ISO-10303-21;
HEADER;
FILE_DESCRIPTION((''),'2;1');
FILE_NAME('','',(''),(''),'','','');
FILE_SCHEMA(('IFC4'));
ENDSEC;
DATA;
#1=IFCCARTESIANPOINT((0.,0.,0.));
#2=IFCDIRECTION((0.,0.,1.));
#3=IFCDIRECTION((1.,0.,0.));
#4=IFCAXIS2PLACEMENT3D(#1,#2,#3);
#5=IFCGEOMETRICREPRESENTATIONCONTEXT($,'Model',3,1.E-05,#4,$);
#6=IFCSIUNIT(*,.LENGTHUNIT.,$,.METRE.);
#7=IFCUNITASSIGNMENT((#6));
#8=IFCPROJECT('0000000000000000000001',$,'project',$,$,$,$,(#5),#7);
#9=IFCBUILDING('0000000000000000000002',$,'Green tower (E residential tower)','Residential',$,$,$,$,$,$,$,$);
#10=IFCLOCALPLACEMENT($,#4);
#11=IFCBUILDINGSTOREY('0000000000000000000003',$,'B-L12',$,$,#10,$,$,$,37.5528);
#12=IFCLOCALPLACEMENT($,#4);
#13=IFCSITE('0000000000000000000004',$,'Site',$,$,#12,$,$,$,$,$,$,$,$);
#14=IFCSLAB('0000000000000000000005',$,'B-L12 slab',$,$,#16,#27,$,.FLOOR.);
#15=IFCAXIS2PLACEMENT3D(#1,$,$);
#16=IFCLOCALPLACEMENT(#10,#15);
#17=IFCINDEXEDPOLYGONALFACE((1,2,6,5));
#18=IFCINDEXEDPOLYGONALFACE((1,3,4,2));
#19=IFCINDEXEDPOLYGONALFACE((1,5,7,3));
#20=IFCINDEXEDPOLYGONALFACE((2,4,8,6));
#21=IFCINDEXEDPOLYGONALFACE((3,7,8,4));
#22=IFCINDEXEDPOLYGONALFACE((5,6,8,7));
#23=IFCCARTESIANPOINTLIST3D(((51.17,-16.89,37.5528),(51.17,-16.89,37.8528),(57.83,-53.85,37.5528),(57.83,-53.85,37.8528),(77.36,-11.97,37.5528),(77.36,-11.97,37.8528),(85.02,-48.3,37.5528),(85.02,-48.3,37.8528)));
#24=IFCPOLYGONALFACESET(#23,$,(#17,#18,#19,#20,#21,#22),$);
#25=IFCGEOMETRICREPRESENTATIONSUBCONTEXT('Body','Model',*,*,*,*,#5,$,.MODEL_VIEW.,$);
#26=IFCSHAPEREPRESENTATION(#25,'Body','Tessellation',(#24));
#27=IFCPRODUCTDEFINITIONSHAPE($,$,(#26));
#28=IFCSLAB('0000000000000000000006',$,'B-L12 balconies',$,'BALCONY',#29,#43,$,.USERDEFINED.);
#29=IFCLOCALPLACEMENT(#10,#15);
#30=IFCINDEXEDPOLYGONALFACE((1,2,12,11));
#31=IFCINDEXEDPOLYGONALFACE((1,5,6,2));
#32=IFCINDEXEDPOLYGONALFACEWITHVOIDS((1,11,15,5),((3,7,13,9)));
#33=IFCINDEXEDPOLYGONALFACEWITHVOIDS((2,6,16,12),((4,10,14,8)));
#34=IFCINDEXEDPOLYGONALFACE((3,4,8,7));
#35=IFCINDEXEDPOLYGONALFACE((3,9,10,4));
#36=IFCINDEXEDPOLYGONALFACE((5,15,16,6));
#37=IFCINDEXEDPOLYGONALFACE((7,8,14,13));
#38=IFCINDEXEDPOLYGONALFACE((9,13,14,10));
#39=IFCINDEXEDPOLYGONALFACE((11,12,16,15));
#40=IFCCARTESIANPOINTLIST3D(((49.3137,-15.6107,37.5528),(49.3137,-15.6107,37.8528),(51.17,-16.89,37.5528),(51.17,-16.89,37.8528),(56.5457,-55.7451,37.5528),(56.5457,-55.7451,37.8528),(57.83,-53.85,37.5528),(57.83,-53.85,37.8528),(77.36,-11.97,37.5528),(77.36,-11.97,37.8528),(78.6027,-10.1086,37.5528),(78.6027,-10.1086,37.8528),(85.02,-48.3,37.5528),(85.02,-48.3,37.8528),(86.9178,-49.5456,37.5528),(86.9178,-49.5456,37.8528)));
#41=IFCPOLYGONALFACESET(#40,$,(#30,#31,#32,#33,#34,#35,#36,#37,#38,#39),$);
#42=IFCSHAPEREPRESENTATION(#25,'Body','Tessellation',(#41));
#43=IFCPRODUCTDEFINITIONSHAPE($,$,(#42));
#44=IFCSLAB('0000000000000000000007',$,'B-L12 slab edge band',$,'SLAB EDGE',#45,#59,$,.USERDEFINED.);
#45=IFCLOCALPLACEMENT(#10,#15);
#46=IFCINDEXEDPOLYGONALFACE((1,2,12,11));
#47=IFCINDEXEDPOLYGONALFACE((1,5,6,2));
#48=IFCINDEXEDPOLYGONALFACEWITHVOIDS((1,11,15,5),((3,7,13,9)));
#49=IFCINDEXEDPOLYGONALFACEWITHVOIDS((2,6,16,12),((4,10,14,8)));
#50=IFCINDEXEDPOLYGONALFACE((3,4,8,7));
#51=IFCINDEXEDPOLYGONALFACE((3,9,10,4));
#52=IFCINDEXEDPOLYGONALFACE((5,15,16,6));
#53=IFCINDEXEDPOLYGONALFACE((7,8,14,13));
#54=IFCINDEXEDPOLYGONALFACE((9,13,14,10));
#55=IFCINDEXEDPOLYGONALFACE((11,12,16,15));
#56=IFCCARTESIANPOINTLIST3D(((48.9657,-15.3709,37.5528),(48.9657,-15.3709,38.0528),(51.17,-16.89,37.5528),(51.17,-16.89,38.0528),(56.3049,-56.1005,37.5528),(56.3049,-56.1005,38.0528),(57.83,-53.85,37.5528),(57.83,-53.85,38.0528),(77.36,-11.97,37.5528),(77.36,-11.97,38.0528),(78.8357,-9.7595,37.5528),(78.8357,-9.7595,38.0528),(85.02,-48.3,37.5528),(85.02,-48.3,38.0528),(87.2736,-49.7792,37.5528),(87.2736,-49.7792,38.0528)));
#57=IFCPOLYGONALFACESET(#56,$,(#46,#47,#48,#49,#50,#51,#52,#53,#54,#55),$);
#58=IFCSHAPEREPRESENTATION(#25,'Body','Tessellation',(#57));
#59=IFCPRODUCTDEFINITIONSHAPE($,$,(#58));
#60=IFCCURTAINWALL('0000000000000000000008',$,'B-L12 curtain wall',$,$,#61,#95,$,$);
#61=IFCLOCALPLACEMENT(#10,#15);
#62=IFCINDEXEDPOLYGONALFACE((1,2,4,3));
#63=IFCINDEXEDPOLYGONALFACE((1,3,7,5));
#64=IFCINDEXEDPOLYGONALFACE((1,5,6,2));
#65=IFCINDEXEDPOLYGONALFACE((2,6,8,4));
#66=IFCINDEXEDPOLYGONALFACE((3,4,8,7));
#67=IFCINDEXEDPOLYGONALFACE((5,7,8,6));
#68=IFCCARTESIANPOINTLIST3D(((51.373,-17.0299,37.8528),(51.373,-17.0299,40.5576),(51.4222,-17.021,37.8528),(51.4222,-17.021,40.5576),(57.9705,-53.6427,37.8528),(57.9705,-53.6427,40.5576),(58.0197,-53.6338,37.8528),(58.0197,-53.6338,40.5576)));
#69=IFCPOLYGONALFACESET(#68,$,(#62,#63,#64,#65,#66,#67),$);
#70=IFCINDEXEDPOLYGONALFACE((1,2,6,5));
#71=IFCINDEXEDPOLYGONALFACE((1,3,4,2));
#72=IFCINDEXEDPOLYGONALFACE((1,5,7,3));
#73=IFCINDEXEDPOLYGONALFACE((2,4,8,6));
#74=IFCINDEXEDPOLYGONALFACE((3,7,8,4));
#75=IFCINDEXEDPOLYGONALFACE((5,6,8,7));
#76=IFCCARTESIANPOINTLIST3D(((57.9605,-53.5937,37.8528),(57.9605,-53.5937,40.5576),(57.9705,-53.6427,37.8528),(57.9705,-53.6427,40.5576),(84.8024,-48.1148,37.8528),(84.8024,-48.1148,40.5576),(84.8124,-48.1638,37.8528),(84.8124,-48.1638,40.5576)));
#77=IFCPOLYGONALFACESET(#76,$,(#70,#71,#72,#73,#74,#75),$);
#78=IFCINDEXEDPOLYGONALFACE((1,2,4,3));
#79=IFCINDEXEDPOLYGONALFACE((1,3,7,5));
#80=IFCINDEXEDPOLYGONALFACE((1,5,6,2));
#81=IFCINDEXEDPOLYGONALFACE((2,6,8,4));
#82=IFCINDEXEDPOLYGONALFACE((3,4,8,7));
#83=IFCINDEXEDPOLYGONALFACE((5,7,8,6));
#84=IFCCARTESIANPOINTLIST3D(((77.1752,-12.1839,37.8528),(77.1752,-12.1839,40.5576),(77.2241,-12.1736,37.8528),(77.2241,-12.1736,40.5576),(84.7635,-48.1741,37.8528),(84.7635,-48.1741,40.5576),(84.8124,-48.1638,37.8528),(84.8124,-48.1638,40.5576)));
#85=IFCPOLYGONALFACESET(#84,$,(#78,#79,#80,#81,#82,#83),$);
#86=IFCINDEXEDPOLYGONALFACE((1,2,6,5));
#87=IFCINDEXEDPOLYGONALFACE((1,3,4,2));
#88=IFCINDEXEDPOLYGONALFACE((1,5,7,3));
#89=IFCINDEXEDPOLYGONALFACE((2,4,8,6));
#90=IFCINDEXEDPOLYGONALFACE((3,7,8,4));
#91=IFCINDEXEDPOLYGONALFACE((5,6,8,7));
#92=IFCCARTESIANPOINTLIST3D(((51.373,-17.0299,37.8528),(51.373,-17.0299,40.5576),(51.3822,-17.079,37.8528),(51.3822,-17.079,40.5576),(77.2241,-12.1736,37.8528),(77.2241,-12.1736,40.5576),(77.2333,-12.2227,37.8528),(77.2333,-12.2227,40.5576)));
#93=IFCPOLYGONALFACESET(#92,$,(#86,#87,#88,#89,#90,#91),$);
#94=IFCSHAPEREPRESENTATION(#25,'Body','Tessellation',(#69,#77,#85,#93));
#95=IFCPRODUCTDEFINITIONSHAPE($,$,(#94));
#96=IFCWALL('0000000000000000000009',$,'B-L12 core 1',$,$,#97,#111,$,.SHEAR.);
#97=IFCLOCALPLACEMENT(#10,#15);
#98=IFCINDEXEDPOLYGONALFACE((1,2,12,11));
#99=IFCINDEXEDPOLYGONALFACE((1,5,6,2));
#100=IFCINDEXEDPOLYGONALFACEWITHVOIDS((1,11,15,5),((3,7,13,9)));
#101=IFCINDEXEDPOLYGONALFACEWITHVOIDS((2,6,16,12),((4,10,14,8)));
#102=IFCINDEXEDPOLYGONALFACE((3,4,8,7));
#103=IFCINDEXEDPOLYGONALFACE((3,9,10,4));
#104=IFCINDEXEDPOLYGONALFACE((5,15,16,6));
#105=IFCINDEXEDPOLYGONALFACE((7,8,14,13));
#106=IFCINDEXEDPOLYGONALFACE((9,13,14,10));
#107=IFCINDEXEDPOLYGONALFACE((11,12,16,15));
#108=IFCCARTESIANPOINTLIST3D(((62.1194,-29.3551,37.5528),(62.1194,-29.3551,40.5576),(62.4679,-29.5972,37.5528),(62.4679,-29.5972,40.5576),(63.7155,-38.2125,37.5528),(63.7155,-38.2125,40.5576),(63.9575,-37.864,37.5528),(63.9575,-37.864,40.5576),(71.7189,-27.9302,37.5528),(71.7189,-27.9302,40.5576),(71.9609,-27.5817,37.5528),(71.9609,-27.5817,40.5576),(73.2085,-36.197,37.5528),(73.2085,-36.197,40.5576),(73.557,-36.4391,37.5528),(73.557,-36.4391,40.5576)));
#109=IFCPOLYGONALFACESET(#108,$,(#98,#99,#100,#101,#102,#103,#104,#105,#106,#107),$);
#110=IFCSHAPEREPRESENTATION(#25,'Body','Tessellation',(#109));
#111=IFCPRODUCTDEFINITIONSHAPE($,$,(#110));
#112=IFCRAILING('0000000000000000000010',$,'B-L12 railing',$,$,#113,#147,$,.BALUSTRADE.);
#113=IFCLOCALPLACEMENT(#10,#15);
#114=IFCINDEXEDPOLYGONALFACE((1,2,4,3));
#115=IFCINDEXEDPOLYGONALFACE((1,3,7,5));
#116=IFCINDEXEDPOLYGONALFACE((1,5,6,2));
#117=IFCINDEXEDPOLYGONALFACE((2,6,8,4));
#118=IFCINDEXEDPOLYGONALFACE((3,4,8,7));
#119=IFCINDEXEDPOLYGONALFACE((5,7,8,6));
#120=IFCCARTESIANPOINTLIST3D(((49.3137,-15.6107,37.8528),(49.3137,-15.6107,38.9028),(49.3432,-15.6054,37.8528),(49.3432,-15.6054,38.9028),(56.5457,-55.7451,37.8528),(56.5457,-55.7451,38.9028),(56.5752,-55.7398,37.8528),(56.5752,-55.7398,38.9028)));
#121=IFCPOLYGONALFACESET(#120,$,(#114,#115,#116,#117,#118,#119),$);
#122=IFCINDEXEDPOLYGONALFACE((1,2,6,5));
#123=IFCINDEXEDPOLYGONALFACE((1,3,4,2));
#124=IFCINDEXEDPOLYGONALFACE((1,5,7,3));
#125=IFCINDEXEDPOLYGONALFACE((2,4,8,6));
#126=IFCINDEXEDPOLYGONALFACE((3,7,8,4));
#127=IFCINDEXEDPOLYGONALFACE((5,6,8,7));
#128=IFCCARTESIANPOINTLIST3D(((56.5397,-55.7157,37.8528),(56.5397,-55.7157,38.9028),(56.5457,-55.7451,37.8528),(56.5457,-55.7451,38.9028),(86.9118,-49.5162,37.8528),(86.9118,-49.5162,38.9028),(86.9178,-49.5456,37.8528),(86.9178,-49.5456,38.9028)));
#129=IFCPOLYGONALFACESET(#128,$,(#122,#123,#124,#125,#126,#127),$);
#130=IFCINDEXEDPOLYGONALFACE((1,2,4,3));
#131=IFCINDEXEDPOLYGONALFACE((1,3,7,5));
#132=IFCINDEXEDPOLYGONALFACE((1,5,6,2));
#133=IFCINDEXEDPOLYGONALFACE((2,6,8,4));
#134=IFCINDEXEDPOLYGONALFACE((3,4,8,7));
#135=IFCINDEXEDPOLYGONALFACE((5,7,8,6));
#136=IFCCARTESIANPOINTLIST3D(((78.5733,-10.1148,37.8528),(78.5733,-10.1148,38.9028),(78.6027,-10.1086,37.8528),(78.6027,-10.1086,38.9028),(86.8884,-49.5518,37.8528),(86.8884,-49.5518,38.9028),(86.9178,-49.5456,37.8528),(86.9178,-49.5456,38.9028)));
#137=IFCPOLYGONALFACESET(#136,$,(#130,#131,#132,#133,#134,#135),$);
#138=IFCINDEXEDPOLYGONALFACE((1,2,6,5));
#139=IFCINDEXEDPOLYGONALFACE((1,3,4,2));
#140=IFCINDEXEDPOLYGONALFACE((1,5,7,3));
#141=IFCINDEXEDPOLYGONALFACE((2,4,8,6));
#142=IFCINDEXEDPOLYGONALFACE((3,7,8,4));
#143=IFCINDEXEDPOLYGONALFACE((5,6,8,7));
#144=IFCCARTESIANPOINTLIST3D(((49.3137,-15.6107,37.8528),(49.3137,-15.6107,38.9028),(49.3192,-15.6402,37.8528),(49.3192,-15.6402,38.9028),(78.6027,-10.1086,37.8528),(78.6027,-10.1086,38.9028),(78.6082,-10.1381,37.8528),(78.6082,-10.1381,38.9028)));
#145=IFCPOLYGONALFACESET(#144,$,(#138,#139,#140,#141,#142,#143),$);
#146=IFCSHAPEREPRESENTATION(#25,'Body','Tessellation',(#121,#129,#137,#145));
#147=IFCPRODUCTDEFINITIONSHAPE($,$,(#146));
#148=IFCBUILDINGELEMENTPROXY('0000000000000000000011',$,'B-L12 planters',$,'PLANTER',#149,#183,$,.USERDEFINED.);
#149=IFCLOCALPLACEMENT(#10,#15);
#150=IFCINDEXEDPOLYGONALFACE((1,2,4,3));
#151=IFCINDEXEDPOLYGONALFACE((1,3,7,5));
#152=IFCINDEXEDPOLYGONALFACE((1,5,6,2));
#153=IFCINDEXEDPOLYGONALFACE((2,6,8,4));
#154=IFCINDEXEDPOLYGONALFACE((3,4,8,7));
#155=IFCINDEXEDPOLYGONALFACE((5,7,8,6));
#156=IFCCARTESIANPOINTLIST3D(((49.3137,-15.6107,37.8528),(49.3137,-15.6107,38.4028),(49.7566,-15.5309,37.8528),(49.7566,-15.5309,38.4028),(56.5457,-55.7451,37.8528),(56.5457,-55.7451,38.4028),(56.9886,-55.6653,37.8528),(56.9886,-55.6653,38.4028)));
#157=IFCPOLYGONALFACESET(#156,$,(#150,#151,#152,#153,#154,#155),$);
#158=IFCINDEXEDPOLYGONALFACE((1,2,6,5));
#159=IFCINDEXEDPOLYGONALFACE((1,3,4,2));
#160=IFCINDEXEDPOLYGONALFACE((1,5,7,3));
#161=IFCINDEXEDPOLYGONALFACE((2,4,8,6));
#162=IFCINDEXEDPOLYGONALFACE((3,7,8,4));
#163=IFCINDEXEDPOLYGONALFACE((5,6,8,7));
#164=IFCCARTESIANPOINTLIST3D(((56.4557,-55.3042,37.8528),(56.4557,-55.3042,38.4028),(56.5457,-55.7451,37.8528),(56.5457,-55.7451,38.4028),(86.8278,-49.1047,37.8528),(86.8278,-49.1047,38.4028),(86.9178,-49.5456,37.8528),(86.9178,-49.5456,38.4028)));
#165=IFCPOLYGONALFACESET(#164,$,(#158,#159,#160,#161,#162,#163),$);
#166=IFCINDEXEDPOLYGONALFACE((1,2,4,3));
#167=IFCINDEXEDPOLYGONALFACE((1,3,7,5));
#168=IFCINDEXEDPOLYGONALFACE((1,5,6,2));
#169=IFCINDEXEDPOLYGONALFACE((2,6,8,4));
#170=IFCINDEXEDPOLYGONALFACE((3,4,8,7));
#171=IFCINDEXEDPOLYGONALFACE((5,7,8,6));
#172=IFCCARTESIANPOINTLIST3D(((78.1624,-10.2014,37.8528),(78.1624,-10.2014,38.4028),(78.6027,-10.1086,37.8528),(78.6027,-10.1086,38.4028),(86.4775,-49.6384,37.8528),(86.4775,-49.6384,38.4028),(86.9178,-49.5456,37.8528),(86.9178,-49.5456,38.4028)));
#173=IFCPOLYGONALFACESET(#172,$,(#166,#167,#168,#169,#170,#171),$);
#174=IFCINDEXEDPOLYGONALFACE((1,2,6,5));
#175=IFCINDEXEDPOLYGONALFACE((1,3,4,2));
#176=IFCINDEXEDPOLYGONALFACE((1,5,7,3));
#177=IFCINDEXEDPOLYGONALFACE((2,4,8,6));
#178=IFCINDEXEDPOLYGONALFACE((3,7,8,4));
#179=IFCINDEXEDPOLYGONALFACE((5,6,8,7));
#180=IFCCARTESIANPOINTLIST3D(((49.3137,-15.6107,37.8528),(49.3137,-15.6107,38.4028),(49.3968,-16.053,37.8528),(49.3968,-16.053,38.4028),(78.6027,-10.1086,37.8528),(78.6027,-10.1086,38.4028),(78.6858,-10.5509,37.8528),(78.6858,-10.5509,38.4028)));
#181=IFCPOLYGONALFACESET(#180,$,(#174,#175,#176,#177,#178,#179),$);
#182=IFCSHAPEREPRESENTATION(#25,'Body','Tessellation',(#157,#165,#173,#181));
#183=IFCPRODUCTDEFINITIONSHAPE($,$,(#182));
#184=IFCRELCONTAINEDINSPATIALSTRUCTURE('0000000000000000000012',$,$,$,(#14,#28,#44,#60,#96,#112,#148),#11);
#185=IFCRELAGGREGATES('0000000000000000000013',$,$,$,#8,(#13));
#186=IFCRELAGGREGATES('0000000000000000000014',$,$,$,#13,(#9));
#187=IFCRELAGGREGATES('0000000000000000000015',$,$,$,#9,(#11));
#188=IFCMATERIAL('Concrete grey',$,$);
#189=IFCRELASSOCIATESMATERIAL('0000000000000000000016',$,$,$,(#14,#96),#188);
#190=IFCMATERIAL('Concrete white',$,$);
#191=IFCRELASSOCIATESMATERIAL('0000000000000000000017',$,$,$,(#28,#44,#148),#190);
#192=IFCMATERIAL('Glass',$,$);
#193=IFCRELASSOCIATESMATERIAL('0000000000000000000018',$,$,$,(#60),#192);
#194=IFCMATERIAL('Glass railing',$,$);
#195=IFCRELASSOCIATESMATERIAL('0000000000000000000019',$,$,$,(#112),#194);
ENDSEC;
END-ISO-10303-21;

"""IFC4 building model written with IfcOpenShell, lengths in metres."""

from ifc_helpers import new_model, si_unit, frame, origin_with_axes, place, context, subcontext, project, spatial, polyline, outline, extrude, material, element, save


model = new_model("IFC4")

# Units and contexts
model_context = context("Model", 3, precision=1e-05, world=origin_with_axes())
body_context = subcontext(model_context, "Body", "Model", "MODEL_VIEW")
ifc_project = project(units=[si_unit("LENGTHUNIT", "METRE")], contexts=[model_context])

# Site, building, storey
site_placement = place(None, origin_with_axes())
site = spatial("IfcSite", under=ifc_project, at=site_placement, Name="Site")
building = spatial("IfcBuilding", under=site, Name="Green tower (E residential tower)", Description="Residential")
storey_placement = place(None, origin_with_axes())
storey = spatial("IfcBuildingStorey", under=building, at=storey_placement, Name="B-L12", Elevation=37.5528)

# Slabs
ifc_material_1 = material(Name="Concrete grey")
slab_1_placement = place(storey_placement, origin_with_axes())
element("IfcSlab", 1, at=slab_1_placement, inside=storey, material=ifc_material_1, Name="B-L12 slab", PredefinedType="FLOOR", context=body_context, shape_type="SweptSolid", body=[
    extrude(outline(polyline([(51.17, -16.89), (57.83, -53.85), (85.02, -48.3), (77.36, -11.97), (51.17, -16.89)])), frame((0.0, 0.0, 37.5528), z_axis=(0.0, 0.0, 1.0), x_axis=(1.0, 0.0, 0.0)), (0.0, 0.0, 1.0), 0.3),
])
ifc_material_2 = material(Name="Concrete white")
slab_2_placement = place(storey_placement, origin_with_axes())
element("IfcSlab", 2, at=slab_2_placement, inside=storey, material=ifc_material_2, Name="B-L12 balconies", ObjectType="BALCONY", PredefinedType="USERDEFINED", context=body_context, shape_type="SweptSolid", body=[
    extrude(outline(polyline([(49.3137, -15.6107), (56.5457, -55.7451), (86.9178, -49.5456), (78.6027, -10.1086), (49.3137, -15.6107)]), holes=[polyline([(51.17, -16.89), (57.83, -53.85), (85.02, -48.3), (77.36, -11.97), (51.17, -16.89)])]), frame((0.0, 0.0, 37.5528), z_axis=(0.0, 0.0, 1.0), x_axis=(1.0, 0.0, 0.0)), (0.0, 0.0, 1.0), 0.3),
])
slab_3_placement = place(storey_placement, origin_with_axes())
element("IfcSlab", 3, at=slab_3_placement, inside=storey, material=ifc_material_2, Name="B-L12 slab edge band", ObjectType="SLAB EDGE", PredefinedType="USERDEFINED", context=body_context, shape_type="SweptSolid", body=[
    extrude(outline(polyline([(48.9657, -15.3709), (56.3049, -56.1005), (87.2736, -49.7792), (78.8357, -9.7595), (48.9657, -15.3709)]), holes=[polyline([(51.17, -16.89), (57.83, -53.85), (85.02, -48.3), (77.36, -11.97), (51.17, -16.89)])]), frame((0.0, 0.0, 37.5528), z_axis=(0.0, 0.0, 1.0), x_axis=(1.0, 0.0, 0.0)), (0.0, 0.0, 1.0), 0.5),
])

# Curtain wall
ifc_material_3 = material(Name="Glass")
curtain_wall_placement = place(storey_placement, origin_with_axes())
element("IfcCurtainWall", 4, at=curtain_wall_placement, inside=storey, material=ifc_material_3, Name="B-L12 curtain wall", context=body_context, shape_type="SweptSolid", body=[
    extrude(outline(polyline([(51.373, -17.0299), (57.9705, -53.6427), (58.0197, -53.6338), (51.4222, -17.021), (51.373, -17.0299)])), frame((0.0, 0.0, 37.8528), z_axis=(0.0, 0.0, 1.0), x_axis=(1.0, 0.0, 0.0)), (0.0, 0.0, 1.0), 2.7048),
    extrude(outline(polyline([(57.9705, -53.6427), (84.8124, -48.1638), (84.8024, -48.1148), (57.9605, -53.5937), (57.9705, -53.6427)])), frame((0.0, 0.0, 37.8528), z_axis=(0.0, 0.0, 1.0), x_axis=(1.0, 0.0, 0.0)), (0.0, 0.0, 1.0), 2.7048),
    extrude(outline(polyline([(84.8124, -48.1638), (77.2241, -12.1736), (77.1752, -12.1839), (84.7635, -48.1741), (84.8124, -48.1638)])), frame((0.0, 0.0, 37.8528), z_axis=(0.0, 0.0, 1.0), x_axis=(1.0, 0.0, 0.0)), (0.0, 0.0, 1.0), 2.7048),
    extrude(outline(polyline([(77.2241, -12.1736), (51.373, -17.0299), (51.3822, -17.079), (77.2333, -12.2227), (77.2241, -12.1736)])), frame((0.0, 0.0, 37.8528), z_axis=(0.0, 0.0, 1.0), x_axis=(1.0, 0.0, 0.0)), (0.0, 0.0, 1.0), 2.7048),
])

# Wall
wall_placement = place(storey_placement, origin_with_axes())
element("IfcWall", 5, at=wall_placement, inside=storey, material=ifc_material_1, Name="B-L12 core 1", PredefinedType="SHEAR", context=body_context, shape_type="SweptSolid", body=[
    extrude(outline(polyline([(62.1194, -29.3551), (63.7155, -38.2125), (73.557, -36.4391), (71.9609, -27.5817), (62.1194, -29.3551)]), holes=[polyline([(62.4679, -29.5972), (63.9575, -37.864), (73.2085, -36.197), (71.7189, -27.9302), (62.4679, -29.5972)])]), frame((0.0, 0.0, 37.5528), z_axis=(0.0, 0.0, 1.0), x_axis=(1.0, 0.0, 0.0)), (0.0, 0.0, 1.0), 3.0048),
])

# Railing
ifc_material_4 = material(Name="Glass railing")
railing_placement = place(storey_placement, origin_with_axes())
element("IfcRailing", 6, at=railing_placement, inside=storey, material=ifc_material_4, Name="B-L12 railing", PredefinedType="BALUSTRADE", context=body_context, shape_type="SweptSolid", body=[
    extrude(outline(polyline([(49.3137, -15.6107), (56.5457, -55.7451), (56.5752, -55.7398), (49.3432, -15.6054), (49.3137, -15.6107)])), frame((0.0, 0.0, 37.8528), z_axis=(0.0, 0.0, 1.0), x_axis=(1.0, 0.0, 0.0)), (0.0, 0.0, 1.0), 1.05),
    extrude(outline(polyline([(56.5457, -55.7451), (86.9178, -49.5456), (86.9118, -49.5162), (56.5397, -55.7157), (56.5457, -55.7451)])), frame((0.0, 0.0, 37.8528), z_axis=(0.0, 0.0, 1.0), x_axis=(1.0, 0.0, 0.0)), (0.0, 0.0, 1.0), 1.05),
    extrude(outline(polyline([(86.9178, -49.5456), (78.6027, -10.1086), (78.5733, -10.1148), (86.8884, -49.5518), (86.9178, -49.5456)])), frame((0.0, 0.0, 37.8528), z_axis=(0.0, 0.0, 1.0), x_axis=(1.0, 0.0, 0.0)), (0.0, 0.0, 1.0), 1.05),
    extrude(outline(polyline([(78.6027, -10.1086), (49.3137, -15.6107), (49.3192, -15.6402), (78.6082, -10.1381), (78.6027, -10.1086)])), frame((0.0, 0.0, 37.8528), z_axis=(0.0, 0.0, 1.0), x_axis=(1.0, 0.0, 0.0)), (0.0, 0.0, 1.0), 1.05),
])

# Building element proxy
proxy_1_placement = place(storey_placement, origin_with_axes())
element("IfcBuildingElementProxy", 7, at=proxy_1_placement, inside=storey, material=ifc_material_2, Name="B-L12 planters", ObjectType="PLANTER", PredefinedType="USERDEFINED", context=body_context, shape_type="SweptSolid", body=[
    extrude(outline(polyline([(49.3137, -15.6107), (56.5457, -55.7451), (56.9886, -55.6653), (49.7566, -15.5309), (49.3137, -15.6107)])), frame((0.0, 0.0, 37.8528), z_axis=(0.0, 0.0, 1.0), x_axis=(1.0, 0.0, 0.0)), (0.0, 0.0, 1.0), 0.55),
    extrude(outline(polyline([(56.5457, -55.7451), (86.9178, -49.5456), (86.8278, -49.1047), (56.4557, -55.3042), (56.5457, -55.7451)])), frame((0.0, 0.0, 37.8528), z_axis=(0.0, 0.0, 1.0), x_axis=(1.0, 0.0, 0.0)), (0.0, 0.0, 1.0), 0.55),
    extrude(outline(polyline([(86.9178, -49.5456), (78.6027, -10.1086), (78.1624, -10.2014), (86.4775, -49.6384), (86.9178, -49.5456)])), frame((0.0, 0.0, 37.8528), z_axis=(0.0, 0.0, 1.0), x_axis=(1.0, 0.0, 0.0)), (0.0, 0.0, 1.0), 0.55),
    extrude(outline(polyline([(78.6027, -10.1086), (49.3137, -15.6107), (49.3968, -16.053), (78.6858, -10.5509), (78.6027, -10.1086)])), frame((0.0, 0.0, 37.8528), z_axis=(0.0, 0.0, 1.0), x_axis=(1.0, 0.0, 0.0)), (0.0, 0.0, 1.0), 0.55),
])

save(model, "model.ifc")
